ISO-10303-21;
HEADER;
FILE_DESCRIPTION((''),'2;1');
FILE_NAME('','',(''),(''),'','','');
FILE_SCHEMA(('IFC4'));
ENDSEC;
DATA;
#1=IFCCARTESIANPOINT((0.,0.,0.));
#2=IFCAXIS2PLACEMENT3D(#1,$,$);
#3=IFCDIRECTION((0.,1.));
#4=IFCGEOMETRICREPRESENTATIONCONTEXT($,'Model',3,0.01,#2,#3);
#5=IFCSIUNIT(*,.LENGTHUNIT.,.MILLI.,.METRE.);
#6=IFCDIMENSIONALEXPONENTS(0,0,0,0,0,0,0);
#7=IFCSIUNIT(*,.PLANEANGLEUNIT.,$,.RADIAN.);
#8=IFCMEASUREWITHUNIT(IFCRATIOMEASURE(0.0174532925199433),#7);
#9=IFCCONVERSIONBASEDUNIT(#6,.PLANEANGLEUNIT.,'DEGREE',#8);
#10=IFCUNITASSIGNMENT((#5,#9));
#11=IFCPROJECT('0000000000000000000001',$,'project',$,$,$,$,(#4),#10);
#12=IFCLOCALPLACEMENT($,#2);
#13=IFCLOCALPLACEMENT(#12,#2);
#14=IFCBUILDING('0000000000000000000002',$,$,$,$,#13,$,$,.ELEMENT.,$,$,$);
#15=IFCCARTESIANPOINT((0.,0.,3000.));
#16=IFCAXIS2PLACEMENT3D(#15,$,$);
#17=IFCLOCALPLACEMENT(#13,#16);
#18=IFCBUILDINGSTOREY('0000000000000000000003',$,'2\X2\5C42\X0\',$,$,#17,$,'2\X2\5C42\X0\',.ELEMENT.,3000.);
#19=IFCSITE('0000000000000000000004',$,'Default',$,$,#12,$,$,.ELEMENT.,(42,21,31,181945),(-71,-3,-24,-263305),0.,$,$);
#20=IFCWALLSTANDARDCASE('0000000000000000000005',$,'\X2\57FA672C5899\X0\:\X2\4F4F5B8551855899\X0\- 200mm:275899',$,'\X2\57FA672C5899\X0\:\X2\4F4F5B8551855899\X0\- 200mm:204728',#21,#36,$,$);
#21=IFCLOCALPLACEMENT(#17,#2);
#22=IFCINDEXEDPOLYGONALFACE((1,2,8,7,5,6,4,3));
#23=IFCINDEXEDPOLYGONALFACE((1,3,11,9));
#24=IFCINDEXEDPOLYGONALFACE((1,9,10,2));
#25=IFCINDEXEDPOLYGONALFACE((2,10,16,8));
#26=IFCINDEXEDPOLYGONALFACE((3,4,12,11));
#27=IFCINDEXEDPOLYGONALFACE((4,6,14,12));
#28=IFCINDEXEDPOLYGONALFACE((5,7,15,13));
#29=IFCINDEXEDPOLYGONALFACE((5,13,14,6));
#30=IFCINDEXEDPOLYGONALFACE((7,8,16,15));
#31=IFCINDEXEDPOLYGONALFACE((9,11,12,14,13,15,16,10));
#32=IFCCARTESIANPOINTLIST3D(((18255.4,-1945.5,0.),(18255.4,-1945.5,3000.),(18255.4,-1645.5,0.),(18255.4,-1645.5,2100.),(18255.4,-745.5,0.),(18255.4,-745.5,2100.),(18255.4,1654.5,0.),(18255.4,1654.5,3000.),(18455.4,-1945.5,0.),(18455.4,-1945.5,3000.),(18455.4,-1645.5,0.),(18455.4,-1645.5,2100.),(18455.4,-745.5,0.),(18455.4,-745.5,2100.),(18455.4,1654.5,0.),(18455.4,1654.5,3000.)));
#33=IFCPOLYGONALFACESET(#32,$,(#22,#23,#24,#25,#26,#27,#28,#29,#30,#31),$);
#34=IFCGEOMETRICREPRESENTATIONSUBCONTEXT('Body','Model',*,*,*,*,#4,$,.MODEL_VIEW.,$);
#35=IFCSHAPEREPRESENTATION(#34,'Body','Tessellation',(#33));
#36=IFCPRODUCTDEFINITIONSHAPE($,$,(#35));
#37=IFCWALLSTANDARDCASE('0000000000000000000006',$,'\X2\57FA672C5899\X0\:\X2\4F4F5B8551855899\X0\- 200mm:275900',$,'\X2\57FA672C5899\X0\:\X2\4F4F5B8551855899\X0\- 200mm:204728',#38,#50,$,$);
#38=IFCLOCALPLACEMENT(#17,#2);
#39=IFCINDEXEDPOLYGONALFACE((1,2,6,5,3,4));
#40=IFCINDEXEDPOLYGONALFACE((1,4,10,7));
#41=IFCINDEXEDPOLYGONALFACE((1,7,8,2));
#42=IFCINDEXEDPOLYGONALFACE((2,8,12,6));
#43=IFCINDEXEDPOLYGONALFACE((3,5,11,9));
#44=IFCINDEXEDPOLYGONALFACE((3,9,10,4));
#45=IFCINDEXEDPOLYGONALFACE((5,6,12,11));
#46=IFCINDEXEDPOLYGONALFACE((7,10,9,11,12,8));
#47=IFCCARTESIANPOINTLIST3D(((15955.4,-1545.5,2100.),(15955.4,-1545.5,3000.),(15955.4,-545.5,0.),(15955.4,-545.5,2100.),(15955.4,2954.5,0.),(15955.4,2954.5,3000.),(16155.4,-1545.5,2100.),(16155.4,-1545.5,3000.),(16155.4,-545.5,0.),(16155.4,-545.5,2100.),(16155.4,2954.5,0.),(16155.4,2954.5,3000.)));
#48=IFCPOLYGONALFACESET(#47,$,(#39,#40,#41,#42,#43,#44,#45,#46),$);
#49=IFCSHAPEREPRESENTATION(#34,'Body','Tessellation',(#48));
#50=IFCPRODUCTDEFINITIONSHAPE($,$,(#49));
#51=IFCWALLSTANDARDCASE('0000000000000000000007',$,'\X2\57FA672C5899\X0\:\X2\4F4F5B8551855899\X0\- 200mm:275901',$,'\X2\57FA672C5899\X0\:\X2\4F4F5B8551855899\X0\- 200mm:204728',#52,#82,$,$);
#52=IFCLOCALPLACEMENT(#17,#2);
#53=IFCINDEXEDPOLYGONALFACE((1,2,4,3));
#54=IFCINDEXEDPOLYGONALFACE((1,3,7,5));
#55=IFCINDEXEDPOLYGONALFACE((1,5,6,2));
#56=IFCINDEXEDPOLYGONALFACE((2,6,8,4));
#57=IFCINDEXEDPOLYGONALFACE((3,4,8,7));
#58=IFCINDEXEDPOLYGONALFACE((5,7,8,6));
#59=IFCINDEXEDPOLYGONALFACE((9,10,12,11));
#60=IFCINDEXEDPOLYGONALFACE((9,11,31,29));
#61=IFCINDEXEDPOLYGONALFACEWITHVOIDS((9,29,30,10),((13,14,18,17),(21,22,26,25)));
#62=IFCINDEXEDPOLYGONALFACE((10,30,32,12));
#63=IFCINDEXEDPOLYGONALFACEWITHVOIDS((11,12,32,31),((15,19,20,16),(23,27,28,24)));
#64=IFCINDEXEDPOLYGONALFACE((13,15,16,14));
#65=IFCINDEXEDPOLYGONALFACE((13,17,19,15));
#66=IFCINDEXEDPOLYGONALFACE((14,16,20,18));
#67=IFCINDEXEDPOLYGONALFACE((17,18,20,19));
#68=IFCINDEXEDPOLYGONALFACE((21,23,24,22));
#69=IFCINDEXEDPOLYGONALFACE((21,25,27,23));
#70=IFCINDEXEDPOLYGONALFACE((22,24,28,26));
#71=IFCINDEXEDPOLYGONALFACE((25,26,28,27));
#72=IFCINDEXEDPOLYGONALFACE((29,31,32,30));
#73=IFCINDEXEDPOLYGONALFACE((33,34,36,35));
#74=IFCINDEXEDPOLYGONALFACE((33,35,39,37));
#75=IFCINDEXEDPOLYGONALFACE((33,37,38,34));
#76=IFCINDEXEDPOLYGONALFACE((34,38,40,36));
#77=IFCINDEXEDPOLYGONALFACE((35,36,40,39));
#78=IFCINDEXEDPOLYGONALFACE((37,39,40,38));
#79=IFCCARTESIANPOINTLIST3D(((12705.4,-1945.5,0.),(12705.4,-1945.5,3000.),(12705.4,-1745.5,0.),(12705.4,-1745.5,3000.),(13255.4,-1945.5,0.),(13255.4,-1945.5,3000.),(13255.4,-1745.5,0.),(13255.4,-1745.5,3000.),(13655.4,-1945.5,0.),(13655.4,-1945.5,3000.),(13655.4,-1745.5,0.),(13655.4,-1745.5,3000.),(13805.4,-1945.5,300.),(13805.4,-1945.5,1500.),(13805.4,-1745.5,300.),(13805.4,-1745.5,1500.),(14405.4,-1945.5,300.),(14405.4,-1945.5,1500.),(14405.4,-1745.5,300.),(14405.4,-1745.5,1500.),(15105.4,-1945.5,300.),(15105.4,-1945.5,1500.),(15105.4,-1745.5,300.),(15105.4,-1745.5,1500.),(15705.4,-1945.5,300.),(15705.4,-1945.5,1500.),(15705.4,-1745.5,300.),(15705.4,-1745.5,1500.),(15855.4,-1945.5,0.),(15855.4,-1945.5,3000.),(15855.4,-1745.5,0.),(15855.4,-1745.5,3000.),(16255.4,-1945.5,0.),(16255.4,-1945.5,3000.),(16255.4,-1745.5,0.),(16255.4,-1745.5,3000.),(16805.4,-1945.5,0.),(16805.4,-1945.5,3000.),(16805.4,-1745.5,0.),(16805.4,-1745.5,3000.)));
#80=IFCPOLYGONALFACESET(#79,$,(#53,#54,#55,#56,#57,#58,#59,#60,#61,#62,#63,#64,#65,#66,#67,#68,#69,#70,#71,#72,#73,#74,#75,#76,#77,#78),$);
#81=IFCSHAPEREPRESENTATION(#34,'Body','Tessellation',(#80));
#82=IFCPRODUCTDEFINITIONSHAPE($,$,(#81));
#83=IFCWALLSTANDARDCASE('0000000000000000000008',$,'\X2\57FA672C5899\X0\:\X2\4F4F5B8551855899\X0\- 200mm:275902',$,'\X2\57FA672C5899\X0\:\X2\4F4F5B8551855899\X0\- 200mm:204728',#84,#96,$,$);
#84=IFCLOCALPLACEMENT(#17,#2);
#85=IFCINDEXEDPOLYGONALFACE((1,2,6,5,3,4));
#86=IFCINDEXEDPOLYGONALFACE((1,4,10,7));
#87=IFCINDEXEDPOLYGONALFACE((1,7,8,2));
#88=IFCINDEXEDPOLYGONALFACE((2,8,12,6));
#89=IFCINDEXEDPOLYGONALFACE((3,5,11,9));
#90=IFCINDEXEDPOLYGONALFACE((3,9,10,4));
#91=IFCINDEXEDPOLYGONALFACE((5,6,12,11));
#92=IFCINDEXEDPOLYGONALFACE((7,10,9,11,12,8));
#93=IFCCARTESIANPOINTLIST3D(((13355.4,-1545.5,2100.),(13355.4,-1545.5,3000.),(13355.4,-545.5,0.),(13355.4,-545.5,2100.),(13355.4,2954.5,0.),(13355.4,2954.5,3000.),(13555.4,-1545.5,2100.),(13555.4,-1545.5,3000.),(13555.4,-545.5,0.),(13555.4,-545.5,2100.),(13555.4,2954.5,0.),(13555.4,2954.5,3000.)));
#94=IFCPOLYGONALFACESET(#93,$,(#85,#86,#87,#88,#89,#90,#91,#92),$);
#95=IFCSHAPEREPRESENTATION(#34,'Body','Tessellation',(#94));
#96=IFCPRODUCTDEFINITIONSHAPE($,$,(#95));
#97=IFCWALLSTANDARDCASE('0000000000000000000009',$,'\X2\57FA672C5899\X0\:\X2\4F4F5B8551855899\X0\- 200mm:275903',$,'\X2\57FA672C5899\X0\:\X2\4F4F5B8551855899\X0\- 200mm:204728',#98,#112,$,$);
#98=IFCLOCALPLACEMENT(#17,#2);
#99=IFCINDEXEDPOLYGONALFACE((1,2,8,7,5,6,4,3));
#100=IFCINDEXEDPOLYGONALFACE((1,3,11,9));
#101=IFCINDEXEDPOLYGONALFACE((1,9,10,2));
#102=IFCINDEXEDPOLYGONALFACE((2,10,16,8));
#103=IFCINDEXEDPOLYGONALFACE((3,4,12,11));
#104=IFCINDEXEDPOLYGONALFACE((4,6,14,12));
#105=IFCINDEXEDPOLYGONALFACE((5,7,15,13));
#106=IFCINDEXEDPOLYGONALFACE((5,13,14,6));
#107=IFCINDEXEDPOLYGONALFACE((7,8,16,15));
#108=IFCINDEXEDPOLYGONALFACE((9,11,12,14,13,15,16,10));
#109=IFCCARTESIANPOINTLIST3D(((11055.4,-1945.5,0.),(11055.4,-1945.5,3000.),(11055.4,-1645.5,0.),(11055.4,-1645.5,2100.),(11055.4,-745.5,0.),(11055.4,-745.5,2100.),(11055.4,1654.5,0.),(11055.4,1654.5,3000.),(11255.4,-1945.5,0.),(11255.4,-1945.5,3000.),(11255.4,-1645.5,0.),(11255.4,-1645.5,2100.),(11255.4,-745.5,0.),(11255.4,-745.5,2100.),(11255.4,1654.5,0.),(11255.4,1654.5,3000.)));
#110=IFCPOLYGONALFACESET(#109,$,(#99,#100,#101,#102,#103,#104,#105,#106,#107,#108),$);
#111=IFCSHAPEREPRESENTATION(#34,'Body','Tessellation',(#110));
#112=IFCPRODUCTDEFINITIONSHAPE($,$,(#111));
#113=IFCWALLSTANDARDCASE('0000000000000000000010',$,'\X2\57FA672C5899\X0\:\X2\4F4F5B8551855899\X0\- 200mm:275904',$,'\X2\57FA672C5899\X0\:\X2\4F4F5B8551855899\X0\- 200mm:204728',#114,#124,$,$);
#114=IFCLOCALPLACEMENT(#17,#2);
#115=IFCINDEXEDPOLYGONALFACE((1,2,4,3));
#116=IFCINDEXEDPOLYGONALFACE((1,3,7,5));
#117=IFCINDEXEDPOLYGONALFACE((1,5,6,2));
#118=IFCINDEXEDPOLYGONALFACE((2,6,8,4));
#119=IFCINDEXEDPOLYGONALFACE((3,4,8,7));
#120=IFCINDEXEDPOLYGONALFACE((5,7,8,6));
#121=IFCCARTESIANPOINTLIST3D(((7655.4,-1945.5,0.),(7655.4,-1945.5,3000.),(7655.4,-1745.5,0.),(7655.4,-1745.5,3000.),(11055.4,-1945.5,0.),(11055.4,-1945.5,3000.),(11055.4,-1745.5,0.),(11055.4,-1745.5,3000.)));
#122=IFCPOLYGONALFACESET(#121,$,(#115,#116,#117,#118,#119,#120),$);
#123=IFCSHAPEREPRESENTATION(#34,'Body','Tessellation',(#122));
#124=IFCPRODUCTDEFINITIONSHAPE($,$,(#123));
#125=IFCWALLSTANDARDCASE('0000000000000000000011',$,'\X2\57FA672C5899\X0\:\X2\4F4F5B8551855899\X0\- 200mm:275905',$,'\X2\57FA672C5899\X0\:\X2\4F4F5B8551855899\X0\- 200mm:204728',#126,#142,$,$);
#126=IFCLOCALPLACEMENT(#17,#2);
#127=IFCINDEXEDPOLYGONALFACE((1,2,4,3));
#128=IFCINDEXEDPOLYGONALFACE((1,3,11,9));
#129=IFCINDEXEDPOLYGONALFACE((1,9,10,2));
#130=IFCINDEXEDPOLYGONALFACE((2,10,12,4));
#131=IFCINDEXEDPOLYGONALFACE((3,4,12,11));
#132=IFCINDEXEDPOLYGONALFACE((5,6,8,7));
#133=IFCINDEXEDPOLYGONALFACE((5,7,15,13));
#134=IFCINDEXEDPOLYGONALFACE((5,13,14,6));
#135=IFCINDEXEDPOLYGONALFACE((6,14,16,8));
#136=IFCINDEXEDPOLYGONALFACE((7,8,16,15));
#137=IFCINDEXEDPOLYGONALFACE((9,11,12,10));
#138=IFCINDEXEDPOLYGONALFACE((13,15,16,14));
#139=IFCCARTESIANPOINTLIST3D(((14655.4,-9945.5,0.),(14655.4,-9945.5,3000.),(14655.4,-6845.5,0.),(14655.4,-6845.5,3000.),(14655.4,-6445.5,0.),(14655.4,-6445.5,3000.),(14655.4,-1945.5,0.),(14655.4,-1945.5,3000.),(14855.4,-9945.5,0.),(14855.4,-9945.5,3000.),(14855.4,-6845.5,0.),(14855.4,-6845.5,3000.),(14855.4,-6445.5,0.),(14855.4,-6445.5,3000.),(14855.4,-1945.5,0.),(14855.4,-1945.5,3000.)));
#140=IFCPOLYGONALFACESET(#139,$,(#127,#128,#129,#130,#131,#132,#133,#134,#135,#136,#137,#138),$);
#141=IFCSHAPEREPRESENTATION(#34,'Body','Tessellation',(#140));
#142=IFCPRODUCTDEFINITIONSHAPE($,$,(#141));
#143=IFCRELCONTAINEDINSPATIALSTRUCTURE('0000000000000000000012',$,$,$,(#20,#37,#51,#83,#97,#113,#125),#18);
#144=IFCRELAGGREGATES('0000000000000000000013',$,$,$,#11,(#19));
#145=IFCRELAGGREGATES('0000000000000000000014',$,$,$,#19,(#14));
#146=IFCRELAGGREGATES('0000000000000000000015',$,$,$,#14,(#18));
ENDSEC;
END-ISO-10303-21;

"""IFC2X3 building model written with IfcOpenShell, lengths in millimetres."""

from ifc_helpers import new_model, entity, si_unit, converted_unit, direction, frame, frame_2d, origin, place, context, subcontext, project, spatial, polyline, rectangle, extrude, clip, bounded_halfspace, element, save


model = new_model("IFC2X3")

# Units and contexts
model_context = context("Model", 3, precision=0.01, world=origin(), true_north=direction((0.0, 1.0)))
body_context = subcontext(model_context, "Body", "Model", "MODEL_VIEW")
ifc_project = project(units=[si_unit("LENGTHUNIT", "METRE", prefix="MILLI"), converted_unit("PLANEANGLEUNIT", "DEGREE", entity("IfcRatioMeasure", 0.0174532925199433), si_unit("PLANEANGLEUNIT", "RADIAN"), dimensions=[0, 0, 0, 0, 0, 0, 0])], contexts=[model_context])

# Site, building, storey
site_placement = place(None, origin())
site = spatial("IfcSite", under=ifc_project, at=site_placement, Name="Default", CompositionType="ELEMENT", RefLatitude=(42, 21, 31, 181945), RefLongitude=(-71, -3, -24, -263305), RefElevation=0.0)
building_placement = place(site_placement, origin())
building = spatial("IfcBuilding", under=site, at=building_placement, CompositionType="ELEMENT")
storey_placement = place(building_placement, frame((0.0, 0.0, 3000.0)))
storey = spatial("IfcBuildingStorey", under=building, at=storey_placement, Name="2层", LongName="2层", CompositionType="ELEMENT", Elevation=3000.0)

# Walls, openings
wall_1_placement = place(storey_placement, frame((18355.4, -1945.5, 0.0), z_axis=(0.0, 0.0, 1.0), x_axis=(0.0, 1.0, 0.0)))
wall_1 = element("IfcWallStandardCase", 1, at=wall_1_placement, inside=storey, Name="基本墙:住宅内墙- 200mm:275899", ObjectType="基本墙:住宅内墙- 200mm:204728", context=body_context, shape_type="SweptSolid", body=[
    extrude(rectangle(XDim=3600.0, YDim=200.0, at=frame_2d((1800.0, 0.0), x_axis=(-1.0, 0.0))), origin(), (0.0, 0.0, 1.0), 3000.0),
])
opening_1_placement = place(wall_1_placement, frame((1200.0, 100.0, 0.0)))
element("IfcOpeningElement", 2, at=opening_1_placement, cuts=wall_1, ObjectType="Opening", context=body_context, shape_type="SweptSolid", body=[
    extrude(rectangle(XDim=2100.0, YDim=900.0, at=frame_2d((1050.0, 450.0), x_axis=(1.0, 0.0))), frame((0.0, 0.0, 0.0), z_axis=(0.0, -1.0, 0.0), x_axis=(0.0, 0.0, 1.0)), (0.0, 0.0, 1.0), 200.0),
])
wall_2_placement = place(storey_placement, frame((16055.4, 2954.5, 0.0), z_axis=(0.0, 0.0, 1.0), x_axis=(0.0, -1.0, 0.0)))
wall_2 = element("IfcWallStandardCase", 3, at=wall_2_placement, inside=storey, Name="基本墙:住宅内墙- 200mm:275900", ObjectType="基本墙:住宅内墙- 200mm:204728", context=body_context, shape_type="Clipping", body=[
    clip(clip(extrude(rectangle(XDim=4500.0, YDim=200.0, at=frame_2d((2250.0, 0.0), x_axis=(-1.0, 0.0))), origin(), (0.0, 0.0, 1.0), 3000.0), bounded_halfspace(frame((4500.0, -100.0, 3000.0), z_axis=(1.0, 0.0, 0.0), x_axis=(0.0, 0.0, -1.0)), False, frame((4500.0, -100.0, 3000.0), z_axis=(1.0, 0.0, 0.0), x_axis=(0.0, 0.0, -1.0)), polyline([(0.0, 0.0), (900.0, 0.0), (900.0, 200.0), (0.0, 200.0), (0.0, 0.0)]))), bounded_halfspace(frame((0.0, -100.0, 0.0), z_axis=(-1.0, 0.0, 0.0), x_axis=(0.0, 0.0, -1.0)), False, frame((0.0, -100.0, 0.0), z_axis=(-1.0, 0.0, 0.0), x_axis=(0.0, 0.0, -1.0)), polyline([(0.0, 0.0), (-3000.0, 0.0), (-3000.0, -200.0), (0.0, -200.0), (0.0, 0.0)]))),
])
opening_2_placement = place(wall_2_placement, frame((4500.0, 100.0, 0.0)))
element("IfcOpeningElement", 4, at=opening_2_placement, cuts=wall_2, ObjectType="Opening", context=body_context, shape_type="SweptSolid", body=[
    extrude(rectangle(XDim=2100.0, YDim=1000.0, at=frame_2d((1050.0, 500.0), x_axis=(1.0, 0.0))), frame((0.0, 0.0, 0.0), z_axis=(0.0, -1.0, 0.0), x_axis=(0.0, 0.0, 1.0)), (0.0, 0.0, 1.0), 200.0),
])

# Wall, openings
wall_3_placement = place(storey_placement, frame((16805.4, -1845.5, 0.0), z_axis=(0.0, 0.0, 1.0), x_axis=(-1.0, 0.0, 0.0)))
wall_3 = element("IfcWallStandardCase", 5, at=wall_3_placement, inside=storey, Name="基本墙:住宅内墙- 200mm:275901", ObjectType="基本墙:住宅内墙- 200mm:204728", context=body_context, shape_type="SweptSolid", body=[
    extrude(rectangle(XDim=4100.0, YDim=200.0, at=frame_2d((2050.0, 0.0), x_axis=(-1.0, 0.0))), origin(), (0.0, 0.0, 1.0), 3000.0),
])
opening_3_placement = place(wall_3_placement, frame((1100.0, -100.0, 300.0)))
element("IfcOpeningElement", 6, at=opening_3_placement, cuts=wall_3, ObjectType="Opening", context=body_context, shape_type="SweptSolid", body=[
    extrude(rectangle(XDim=1200.0, YDim=600.0, at=frame_2d((600.0, 300.0), x_axis=(-1.0, 0.0))), frame((0.0, 0.0, 0.0), z_axis=(0.0, 1.0, 0.0), x_axis=(0.0, 0.0, 1.0)), (0.0, 0.0, 1.0), 200.0),
])
opening_4_placement = place(wall_3_placement, frame((2400.0, -100.0, 300.0)))
element("IfcOpeningElement", 7, at=opening_4_placement, cuts=wall_3, ObjectType="Opening", context=body_context, shape_type="SweptSolid", body=[
    extrude(rectangle(XDim=1200.0, YDim=600.0, at=frame_2d((600.0, 300.0), x_axis=(-1.0, 0.0))), frame((0.0, 0.0, 0.0), z_axis=(0.0, 1.0, 0.0), x_axis=(0.0, 0.0, 1.0)), (0.0, 0.0, 1.0), 200.0),
])
opening_5_placement = place(storey_placement, frame((16805.4, -1845.5, 0.0), z_axis=(0.0, 0.0, 1.0), x_axis=(-1.0, 0.0, 0.0)))
element("IfcOpeningElement", 8, at=opening_5_placement, cuts=wall_3, ObjectType="Opening", context=body_context, shape_type="SweptSolid", body=[
    extrude(rectangle(XDim=3000.0, YDim=200.0, at=frame_2d((0.0, 0.0), x_axis=(1.0, 0.0))), frame((3550.0, 0.0, 1500.0), z_axis=(-1.0, 0.0, 0.0), x_axis=(0.0, 0.0, 1.0)), (0.0, 0.0, 1.0), 400.0),
])
opening_6_placement = place(storey_placement, frame((16805.4, -1845.5, 0.0), z_axis=(0.0, 0.0, 1.0), x_axis=(-1.0, 0.0, 0.0)))
element("IfcOpeningElement", 9, at=opening_6_placement, cuts=wall_3, ObjectType="Opening", context=body_context, shape_type="SweptSolid", body=[
    extrude(rectangle(XDim=3000.0, YDim=200.0, at=frame_2d((0.0, 0.0), x_axis=(1.0, 0.0))), frame((950.0, 0.0, 1500.0), z_axis=(-1.0, 0.0, 0.0), x_axis=(0.0, 0.0, 1.0)), (0.0, 0.0, 1.0), 400.0),
])

# Walls, openings
wall_4_placement = place(storey_placement, frame((13455.4, -1545.5, 0.0), z_axis=(0.0, 0.0, 1.0), x_axis=(0.0, 1.0, 0.0)))
wall_4 = element("IfcWallStandardCase", 10, at=wall_4_placement, inside=storey, Name="基本墙:住宅内墙- 200mm:275902", ObjectType="基本墙:住宅内墙- 200mm:204728", context=body_context, shape_type="Clipping", body=[
    clip(clip(extrude(rectangle(XDim=4500.0, YDim=200.0, at=frame_2d((2250.0, 0.0), x_axis=(-1.0, 0.0))), origin(), (0.0, 0.0, 1.0), 3000.0), bounded_halfspace(frame((0.0, -100.0, 2100.0), z_axis=(1.0, 0.0, 0.0), x_axis=(0.0, 0.0, -1.0)), True, frame((0.0, -100.0, 2100.0), z_axis=(1.0, 0.0, 0.0), x_axis=(0.0, 0.0, -1.0)), polyline([(0.0, 0.0), (0.0, 200.0), (-900.0, 200.0), (-900.0, 0.0), (0.0, 0.0)]))), bounded_halfspace(frame((4500.0, -100.0, 3000.0), z_axis=(-1.0, 0.0, 0.0), x_axis=(0.0, 0.0, -1.0)), True, frame((4500.0, -100.0, 3000.0), z_axis=(-1.0, 0.0, 0.0), x_axis=(0.0, 0.0, -1.0)), polyline([(0.0, 0.0), (0.0, -200.0), (3000.0, -200.0), (3000.0, 0.0), (0.0, 0.0)]))),
])
opening_7_placement = place(wall_4_placement, frame((1000.0, 100.0, 0.0)))
element("IfcOpeningElement", 11, at=opening_7_placement, cuts=wall_4, ObjectType="Opening", context=body_context, shape_type="SweptSolid", body=[
    extrude(rectangle(XDim=2100.0, YDim=1000.0, at=frame_2d((1050.0, 500.0), x_axis=(1.0, 0.0))), frame((0.0, 0.0, 0.0), z_axis=(0.0, -1.0, 0.0), x_axis=(0.0, 0.0, 1.0)), (0.0, 0.0, 1.0), 200.0),
])
wall_5_placement = place(storey_placement, frame((11155.4, 1654.5, 0.0), z_axis=(0.0, 0.0, 1.0), x_axis=(0.0, -1.0, 0.0)))
wall_5 = element("IfcWallStandardCase", 12, at=wall_5_placement, inside=storey, Name="基本墙:住宅内墙- 200mm:275903", ObjectType="基本墙:住宅内墙- 200mm:204728", context=body_context, shape_type="SweptSolid", body=[
    extrude(rectangle(XDim=3600.0, YDim=200.0, at=frame_2d((1800.0, 0.0), x_axis=(-1.0, 0.0))), origin(), (0.0, 0.0, 1.0), 3000.0),
])
opening_8_placement = place(wall_5_placement, frame((3300.0, 100.0, 0.0)))
element("IfcOpeningElement", 13, at=opening_8_placement, cuts=wall_5, ObjectType="Opening", context=body_context, shape_type="SweptSolid", body=[
    extrude(rectangle(XDim=2100.0, YDim=900.0, at=frame_2d((1050.0, 450.0), x_axis=(1.0, 0.0))), frame((0.0, 0.0, 0.0), z_axis=(0.0, -1.0, 0.0), x_axis=(0.0, 0.0, 1.0)), (0.0, 0.0, 1.0), 200.0),
])

# Wall
wall_6_placement = place(storey_placement, frame((11055.4, -1845.5, 0.0), z_axis=(0.0, 0.0, 1.0), x_axis=(-1.0, 0.0, 0.0)))
element("IfcWallStandardCase", 14, at=wall_6_placement, inside=storey, Name="基本墙:住宅内墙- 200mm:275904", ObjectType="基本墙:住宅内墙- 200mm:204728", context=body_context, shape_type="SweptSolid", body=[
    extrude(rectangle(XDim=3400.0, YDim=200.0, at=frame_2d((1700.0, 0.0), x_axis=(-1.0, 0.0))), origin(), (0.0, 0.0, 1.0), 3000.0),
])

# Wall, opening
wall_7_placement = place(storey_placement, frame((14755.4, -1945.5, 0.0), z_axis=(0.0, 0.0, 1.0), x_axis=(0.0, -1.0, 0.0)))
wall_7 = element("IfcWallStandardCase", 15, at=wall_7_placement, inside=storey, Name="基本墙:住宅内墙- 200mm:275905", ObjectType="基本墙:住宅内墙- 200mm:204728", context=body_context, shape_type="Clipping", body=[
    clip(extrude(rectangle(XDim=8000.0, YDim=200.0, at=frame_2d((4000.0, 0.0), x_axis=(-1.0, 0.0))), origin(), (0.0, 0.0, 1.0), 3000.0), bounded_halfspace(frame((8000.0, -100.0, 3000.0), z_axis=(1.0, 0.0, 0.0), x_axis=(0.0, 0.0, -1.0)), False, frame((8000.0, -100.0, 3000.0), z_axis=(1.0, 0.0, 0.0), x_axis=(0.0, 0.0, -1.0)), polyline([(0.0, 0.0), (3000.0, 0.0), (3000.0, 200.0), (0.0, 200.0), (0.0, 0.0)]))),
])
opening_9_placement = place(storey_placement, frame((14755.4, -1945.5, 0.0), z_axis=(0.0, 0.0, 1.0), x_axis=(0.0, -1.0, 0.0)))
element("IfcOpeningElement", 16, at=opening_9_placement, cuts=wall_7, ObjectType="Opening", context=body_context, shape_type="SweptSolid", body=[
    extrude(rectangle(XDim=3000.0, YDim=200.0, at=frame_2d((0.0, 0.0), x_axis=(1.0, 0.0))), frame((4900.0, 0.0, 1500.0), z_axis=(-1.0, 0.0, 0.0), x_axis=(0.0, 0.0, 1.0)), (0.0, 0.0, 1.0), 400.0),
])

save(model, "model.ifc")
